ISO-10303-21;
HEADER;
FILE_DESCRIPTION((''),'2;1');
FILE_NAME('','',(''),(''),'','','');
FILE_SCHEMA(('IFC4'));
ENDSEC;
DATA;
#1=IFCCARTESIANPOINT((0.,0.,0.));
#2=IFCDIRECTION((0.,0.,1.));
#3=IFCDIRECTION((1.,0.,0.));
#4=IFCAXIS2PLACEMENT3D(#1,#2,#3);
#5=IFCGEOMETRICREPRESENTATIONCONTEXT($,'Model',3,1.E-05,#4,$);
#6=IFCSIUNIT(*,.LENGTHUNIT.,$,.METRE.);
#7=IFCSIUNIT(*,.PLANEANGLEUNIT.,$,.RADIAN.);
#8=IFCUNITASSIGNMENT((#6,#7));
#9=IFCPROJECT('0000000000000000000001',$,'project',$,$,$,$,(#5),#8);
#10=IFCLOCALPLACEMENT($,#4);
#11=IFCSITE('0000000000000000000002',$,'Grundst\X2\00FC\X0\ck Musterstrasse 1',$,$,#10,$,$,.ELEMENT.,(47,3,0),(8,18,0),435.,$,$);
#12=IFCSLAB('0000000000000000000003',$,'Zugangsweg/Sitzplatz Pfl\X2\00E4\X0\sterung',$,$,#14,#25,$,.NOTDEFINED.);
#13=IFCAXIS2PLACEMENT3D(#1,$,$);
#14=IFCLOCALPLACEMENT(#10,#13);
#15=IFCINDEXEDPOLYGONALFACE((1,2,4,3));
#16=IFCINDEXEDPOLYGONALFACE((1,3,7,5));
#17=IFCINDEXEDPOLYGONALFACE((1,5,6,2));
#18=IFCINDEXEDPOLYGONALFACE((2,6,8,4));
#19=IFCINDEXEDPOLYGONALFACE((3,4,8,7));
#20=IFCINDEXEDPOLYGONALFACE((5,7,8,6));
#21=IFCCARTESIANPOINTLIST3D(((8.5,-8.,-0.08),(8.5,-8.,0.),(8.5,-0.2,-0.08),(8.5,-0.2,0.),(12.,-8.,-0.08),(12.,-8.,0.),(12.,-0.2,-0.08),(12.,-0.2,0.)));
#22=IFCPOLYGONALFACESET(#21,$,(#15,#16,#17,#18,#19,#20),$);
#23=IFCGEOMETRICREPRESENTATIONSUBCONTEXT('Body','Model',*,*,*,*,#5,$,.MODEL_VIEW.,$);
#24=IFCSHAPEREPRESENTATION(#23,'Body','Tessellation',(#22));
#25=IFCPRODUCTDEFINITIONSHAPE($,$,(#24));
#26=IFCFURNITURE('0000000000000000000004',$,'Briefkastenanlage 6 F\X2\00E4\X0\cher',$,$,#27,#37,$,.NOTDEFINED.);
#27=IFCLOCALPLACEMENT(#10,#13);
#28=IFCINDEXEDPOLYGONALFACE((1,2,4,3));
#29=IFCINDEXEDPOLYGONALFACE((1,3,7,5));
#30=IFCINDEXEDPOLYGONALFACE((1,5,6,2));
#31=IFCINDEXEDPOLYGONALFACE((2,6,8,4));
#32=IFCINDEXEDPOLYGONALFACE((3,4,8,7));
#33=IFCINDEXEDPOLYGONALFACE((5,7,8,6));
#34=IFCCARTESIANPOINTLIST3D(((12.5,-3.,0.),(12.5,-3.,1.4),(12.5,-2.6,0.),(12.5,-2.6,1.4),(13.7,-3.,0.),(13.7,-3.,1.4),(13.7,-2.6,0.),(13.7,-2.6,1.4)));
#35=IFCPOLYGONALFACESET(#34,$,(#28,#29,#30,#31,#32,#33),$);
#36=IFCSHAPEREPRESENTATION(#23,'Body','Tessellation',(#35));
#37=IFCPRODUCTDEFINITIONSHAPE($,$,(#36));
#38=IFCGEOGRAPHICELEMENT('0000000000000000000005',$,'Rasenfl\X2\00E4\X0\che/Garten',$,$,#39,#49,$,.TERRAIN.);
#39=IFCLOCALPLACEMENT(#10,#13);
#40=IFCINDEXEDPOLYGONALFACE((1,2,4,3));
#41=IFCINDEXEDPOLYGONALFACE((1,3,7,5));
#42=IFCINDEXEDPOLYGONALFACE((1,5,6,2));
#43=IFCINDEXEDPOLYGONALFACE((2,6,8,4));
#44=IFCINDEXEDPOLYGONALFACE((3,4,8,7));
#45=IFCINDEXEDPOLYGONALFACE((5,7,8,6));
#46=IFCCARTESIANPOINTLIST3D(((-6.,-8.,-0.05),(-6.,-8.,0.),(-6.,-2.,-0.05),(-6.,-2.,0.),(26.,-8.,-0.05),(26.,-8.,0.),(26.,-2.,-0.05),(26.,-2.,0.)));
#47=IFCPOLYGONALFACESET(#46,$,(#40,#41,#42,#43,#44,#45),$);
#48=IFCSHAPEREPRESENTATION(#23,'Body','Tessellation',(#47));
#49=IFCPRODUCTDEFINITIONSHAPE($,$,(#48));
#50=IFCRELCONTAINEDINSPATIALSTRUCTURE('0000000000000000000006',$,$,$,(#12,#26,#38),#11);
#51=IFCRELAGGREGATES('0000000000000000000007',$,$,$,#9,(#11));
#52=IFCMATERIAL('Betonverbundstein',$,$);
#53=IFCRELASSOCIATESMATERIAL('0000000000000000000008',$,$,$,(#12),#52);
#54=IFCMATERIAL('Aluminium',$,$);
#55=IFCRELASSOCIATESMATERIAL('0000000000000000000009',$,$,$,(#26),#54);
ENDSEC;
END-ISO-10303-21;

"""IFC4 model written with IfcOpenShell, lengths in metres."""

from ifc_helpers import new_model, si_unit, frame, frame_2d, origin_with_axes, place, context, subcontext, project, spatial, rectangle, extrude, material, element, save


model = new_model("IFC4")

# Units and contexts
model_context = context("Model", 3, precision=1e-05, world=origin_with_axes())
body_context = subcontext(model_context, "Body", "Model", "MODEL_VIEW")
ifc_project = project(units=[si_unit("LENGTHUNIT", "METRE"), si_unit("PLANEANGLEUNIT", "RADIAN")], contexts=[model_context])

# Site
site_placement = place(None, origin_with_axes())
site = spatial("IfcSite", under=ifc_project, at=site_placement, Name="Grundstück Musterstrasse 1", CompositionType="ELEMENT", RefLatitude=(47, 3, 0), RefLongitude=(8, 18, 0), RefElevation=435.0)

# Slab
ifc_material_1 = material(Name="Betonverbundstein")
slab_placement = place(site_placement, origin_with_axes())
element("IfcSlab", 1, at=slab_placement, inside=site, material=ifc_material_1, Name="Zugangsweg/Sitzplatz Pflästerung", PredefinedType="NOTDEFINED", context=body_context, shape_type="SweptSolid", body=[
    extrude(rectangle(XDim=3.5, YDim=7.8, at=frame_2d((1.75, 3.9), x_axis=(1.0, 0.0))), frame((8.5, -8.0, -0.08), z_axis=(0.0, 0.0, 1.0), x_axis=(1.0, 0.0, 0.0)), (0.0, 0.0, 1.0), 0.08),
])

# Furniture
ifc_material_2 = material(Name="Aluminium")
furniture_placement = place(site_placement, origin_with_axes())
element("IfcFurniture", 2, at=furniture_placement, inside=site, material=ifc_material_2, Name="Briefkastenanlage 6 Fächer", PredefinedType="NOTDEFINED", context=body_context, shape_type="SweptSolid", body=[
    extrude(rectangle(XDim=1.2, YDim=0.4, at=frame_2d((0.6, 0.2), x_axis=(1.0, 0.0))), frame((12.5, -3.0, 0.0), z_axis=(0.0, 0.0, 1.0), x_axis=(1.0, 0.0, 0.0)), (0.0, 0.0, 1.0), 1.4),
])

# Geographic element
geographic_element_placement = place(site_placement, origin_with_axes())
element("IfcGeographicElement", 3, at=geographic_element_placement, inside=site, Name="Rasenfläche/Garten", PredefinedType="TERRAIN", context=body_context, shape_type="SweptSolid", body=[
    extrude(rectangle(XDim=32.0, YDim=6.0, at=frame_2d((16.0, 3.0), x_axis=(1.0, 0.0))), frame((-6.0, -8.0, -0.05), z_axis=(0.0, 0.0, 1.0), x_axis=(1.0, 0.0, 0.0)), (0.0, 0.0, 1.0), 0.05),
])

save(model, "model.ifc")
